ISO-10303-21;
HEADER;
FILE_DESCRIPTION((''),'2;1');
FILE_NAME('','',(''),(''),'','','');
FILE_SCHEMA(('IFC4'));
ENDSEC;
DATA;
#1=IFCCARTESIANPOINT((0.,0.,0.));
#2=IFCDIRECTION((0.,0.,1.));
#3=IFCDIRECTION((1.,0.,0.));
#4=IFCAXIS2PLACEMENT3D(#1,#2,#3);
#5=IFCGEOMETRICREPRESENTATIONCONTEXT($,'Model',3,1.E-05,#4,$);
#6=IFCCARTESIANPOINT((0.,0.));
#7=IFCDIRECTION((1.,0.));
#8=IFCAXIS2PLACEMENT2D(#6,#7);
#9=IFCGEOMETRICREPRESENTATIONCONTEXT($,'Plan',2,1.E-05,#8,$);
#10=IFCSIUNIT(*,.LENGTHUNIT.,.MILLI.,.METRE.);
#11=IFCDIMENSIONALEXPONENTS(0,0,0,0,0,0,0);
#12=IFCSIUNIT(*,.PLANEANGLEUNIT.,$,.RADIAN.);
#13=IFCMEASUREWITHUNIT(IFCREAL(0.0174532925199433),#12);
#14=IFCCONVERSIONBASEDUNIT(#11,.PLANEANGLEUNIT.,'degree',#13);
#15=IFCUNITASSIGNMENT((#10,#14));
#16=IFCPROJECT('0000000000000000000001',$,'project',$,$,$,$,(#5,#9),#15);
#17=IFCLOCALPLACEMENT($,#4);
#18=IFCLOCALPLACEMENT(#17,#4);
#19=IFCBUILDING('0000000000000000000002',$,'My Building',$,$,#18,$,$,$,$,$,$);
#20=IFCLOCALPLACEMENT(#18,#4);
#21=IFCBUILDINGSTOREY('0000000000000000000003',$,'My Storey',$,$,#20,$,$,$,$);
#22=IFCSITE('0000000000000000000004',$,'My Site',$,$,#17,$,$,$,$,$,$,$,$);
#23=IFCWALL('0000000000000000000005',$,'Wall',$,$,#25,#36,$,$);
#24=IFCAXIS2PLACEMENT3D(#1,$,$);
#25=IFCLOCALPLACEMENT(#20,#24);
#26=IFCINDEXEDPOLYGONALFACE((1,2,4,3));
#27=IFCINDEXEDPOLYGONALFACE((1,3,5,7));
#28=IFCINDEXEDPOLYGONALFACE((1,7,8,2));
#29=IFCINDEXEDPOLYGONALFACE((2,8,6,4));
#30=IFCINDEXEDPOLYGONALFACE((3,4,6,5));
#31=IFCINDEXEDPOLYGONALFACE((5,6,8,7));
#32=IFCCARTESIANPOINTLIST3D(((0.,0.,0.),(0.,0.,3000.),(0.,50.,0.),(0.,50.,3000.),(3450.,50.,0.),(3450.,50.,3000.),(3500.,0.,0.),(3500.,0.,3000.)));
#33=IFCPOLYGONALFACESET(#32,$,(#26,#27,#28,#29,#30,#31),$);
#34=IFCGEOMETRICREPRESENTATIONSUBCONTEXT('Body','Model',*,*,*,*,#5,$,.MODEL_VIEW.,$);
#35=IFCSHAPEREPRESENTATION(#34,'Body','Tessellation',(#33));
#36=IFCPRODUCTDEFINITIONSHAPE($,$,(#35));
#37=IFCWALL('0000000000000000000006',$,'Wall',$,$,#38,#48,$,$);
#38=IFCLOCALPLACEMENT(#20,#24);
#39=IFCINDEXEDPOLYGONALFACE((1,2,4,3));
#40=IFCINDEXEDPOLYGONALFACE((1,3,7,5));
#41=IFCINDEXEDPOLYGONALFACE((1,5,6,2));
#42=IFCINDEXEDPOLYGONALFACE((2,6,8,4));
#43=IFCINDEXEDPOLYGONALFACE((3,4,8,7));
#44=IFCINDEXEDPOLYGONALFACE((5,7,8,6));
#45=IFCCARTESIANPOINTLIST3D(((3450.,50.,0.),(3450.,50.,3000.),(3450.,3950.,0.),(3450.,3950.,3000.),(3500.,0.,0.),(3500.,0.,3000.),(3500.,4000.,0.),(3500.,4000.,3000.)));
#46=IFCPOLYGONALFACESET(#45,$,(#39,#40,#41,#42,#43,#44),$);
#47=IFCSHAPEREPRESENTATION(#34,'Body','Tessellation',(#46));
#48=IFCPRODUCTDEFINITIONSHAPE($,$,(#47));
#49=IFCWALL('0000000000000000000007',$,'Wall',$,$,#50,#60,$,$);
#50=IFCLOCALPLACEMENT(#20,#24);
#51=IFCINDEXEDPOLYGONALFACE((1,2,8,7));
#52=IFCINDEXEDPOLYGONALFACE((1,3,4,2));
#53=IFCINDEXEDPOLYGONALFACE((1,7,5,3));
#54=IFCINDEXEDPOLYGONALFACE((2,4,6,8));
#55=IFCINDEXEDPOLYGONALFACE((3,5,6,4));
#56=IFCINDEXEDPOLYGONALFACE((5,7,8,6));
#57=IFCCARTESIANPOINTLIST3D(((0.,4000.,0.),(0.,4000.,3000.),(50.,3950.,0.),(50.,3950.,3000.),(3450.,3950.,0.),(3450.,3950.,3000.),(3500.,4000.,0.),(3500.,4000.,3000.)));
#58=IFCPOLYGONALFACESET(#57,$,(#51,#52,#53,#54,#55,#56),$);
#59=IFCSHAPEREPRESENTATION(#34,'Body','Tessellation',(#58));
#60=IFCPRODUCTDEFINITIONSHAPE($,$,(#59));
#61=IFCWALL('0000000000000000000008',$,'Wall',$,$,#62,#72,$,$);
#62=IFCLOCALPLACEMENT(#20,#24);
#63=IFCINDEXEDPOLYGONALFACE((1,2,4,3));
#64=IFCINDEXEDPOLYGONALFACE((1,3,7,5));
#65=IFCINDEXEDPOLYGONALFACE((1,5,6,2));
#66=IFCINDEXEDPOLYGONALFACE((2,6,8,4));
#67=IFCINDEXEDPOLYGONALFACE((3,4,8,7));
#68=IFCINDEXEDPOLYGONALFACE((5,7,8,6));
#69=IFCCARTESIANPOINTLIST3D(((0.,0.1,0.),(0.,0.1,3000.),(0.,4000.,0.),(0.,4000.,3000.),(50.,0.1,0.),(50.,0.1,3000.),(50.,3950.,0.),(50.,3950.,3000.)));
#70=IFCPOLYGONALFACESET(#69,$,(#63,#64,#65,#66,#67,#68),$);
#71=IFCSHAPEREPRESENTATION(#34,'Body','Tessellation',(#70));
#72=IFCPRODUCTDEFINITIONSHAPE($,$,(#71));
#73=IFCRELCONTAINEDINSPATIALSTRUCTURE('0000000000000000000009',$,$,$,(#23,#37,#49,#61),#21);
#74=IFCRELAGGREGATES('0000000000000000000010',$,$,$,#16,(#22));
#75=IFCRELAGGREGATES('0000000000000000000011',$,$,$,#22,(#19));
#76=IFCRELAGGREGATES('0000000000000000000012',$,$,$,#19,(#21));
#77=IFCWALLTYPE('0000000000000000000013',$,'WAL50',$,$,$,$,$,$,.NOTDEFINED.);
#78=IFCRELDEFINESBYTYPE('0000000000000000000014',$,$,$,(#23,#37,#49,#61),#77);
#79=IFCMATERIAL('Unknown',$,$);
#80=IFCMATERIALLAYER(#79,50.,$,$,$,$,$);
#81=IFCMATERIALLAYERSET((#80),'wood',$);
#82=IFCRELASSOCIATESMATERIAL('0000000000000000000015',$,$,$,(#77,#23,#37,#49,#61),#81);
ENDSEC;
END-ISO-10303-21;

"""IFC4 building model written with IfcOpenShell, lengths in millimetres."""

from ifc_helpers import new_model, entity, si_unit, converted_unit, frame, origin_with_axes, origin_2d_with_axis, place, context, subcontext, project, spatial, line, indexed_curve, outline, extrude, material, layer, layer_set, layer_usage, type_object, element, save


model = new_model("IFC4")

# Units and contexts
model_context = context("Model", 3, precision=1e-05, world=origin_with_axes())
plan_context = context("Plan", 2, precision=1e-05, world=origin_2d_with_axis())
body_context = subcontext(model_context, "Body", "Model", "MODEL_VIEW")
ifc_project = project(units=[si_unit("LENGTHUNIT", "METRE", prefix="MILLI"), converted_unit("PLANEANGLEUNIT", "degree", entity("IfcReal", 0.0174532925199433), si_unit("PLANEANGLEUNIT", "RADIAN"), dimensions=[0, 0, 0, 0, 0, 0, 0])], contexts=[model_context, plan_context])

# Site, building, storey
site_placement = place(None, origin_with_axes())
site = spatial("IfcSite", under=ifc_project, at=site_placement, Name="My Site")
building_placement = place(site_placement, origin_with_axes())
building = spatial("IfcBuilding", under=site, at=building_placement, Name="My Building")
storey_placement = place(building_placement, origin_with_axes())
storey = spatial("IfcBuildingStorey", under=building, at=storey_placement, Name="My Storey")

# Walls
ifc_material = material(Name="Unknown")
ifc_layer = layer(ifc_material, 50.0)
ifc_layer_set = layer_set([ifc_layer], Name="wood")
ifc_layer_usage_1 = layer_usage(ifc_layer_set, "AXIS2", "POSITIVE", 0.0)
wall_type = type_object("IfcWallType", Name="WAL50", PredefinedType="NOTDEFINED", material=ifc_layer_set)
wall_1_placement = place(storey_placement, origin_with_axes())
element("IfcWall", 1, at=wall_1_placement, inside=storey, type_object=wall_type, material=ifc_layer_usage_1, Name="Wall", context=body_context, shape_type="SweptSolid", body=[
    extrude(outline(indexed_curve([(0.0, 0.0), (0.0, 50.0), (3450.0, 50.0), (3500.0, 0.0)], segments=[line(1, 2, 3, 4, 1)])), origin_with_axes(), (0.0, 0.0, 1.0), 3000.0),
])
ifc_layer_usage_2 = layer_usage(ifc_layer_set, "AXIS2", "POSITIVE", 0.0)
wall_2_placement = place(storey_placement, frame((3500.0, 0.0, 0.0), z_axis=(0.0, 0.0, 1.0), x_axis=(0.0, 1.0, 0.0)))
element("IfcWall", 2, at=wall_2_placement, inside=storey, type_object=wall_type, material=ifc_layer_usage_2, Name="Wall", context=body_context, shape_type="SweptSolid", body=[
    extrude(outline(indexed_curve([(0.0, 0.0), (50.0, 50.0), (3950.0, 50.0), (4000.0, 0.0)], segments=[line(1, 2, 3, 4, 1)])), origin_with_axes(), (0.0, 0.0, 1.0), 3000.0),
])
ifc_layer_usage_3 = layer_usage(ifc_layer_set, "AXIS2", "POSITIVE", 0.0)
wall_3_placement = place(storey_placement, frame((3500.0, 4000.0, 0.0), z_axis=(0.0, 0.0, 1.0), x_axis=(-1.0, 0.0, 0.0)))
element("IfcWall", 3, at=wall_3_placement, inside=storey, type_object=wall_type, material=ifc_layer_usage_3, Name="Wall", context=body_context, shape_type="SweptSolid", body=[
    extrude(outline(indexed_curve([(0.0, 0.0), (50.0, 50.0), (3450.0, 50.0), (3500.0, 0.0)], segments=[line(1, 2, 3, 4, 1)])), origin_with_axes(), (0.0, 0.0, 1.0), 3000.0),
])
ifc_layer_usage_4 = layer_usage(ifc_layer_set, "AXIS2", "POSITIVE", 0.0)
wall_4_placement = place(storey_placement, frame((0.0, 4000.0, 0.0), z_axis=(0.0, 0.0, 1.0), x_axis=(0.0, -1.0, 0.0)))
element("IfcWall", 4, at=wall_4_placement, inside=storey, type_object=wall_type, material=ifc_layer_usage_4, Name="Wall", context=body_context, shape_type="SweptSolid", body=[
    extrude(outline(indexed_curve([(0.0, 0.0), (50.0, 50.0), (3999.9, 50.0), (3999.9, 0.0)], segments=[line(1, 2, 3, 4, 1)])), origin_with_axes(), (0.0, 0.0, 1.0), 3000.0),
])

save(model, "model.ifc")
